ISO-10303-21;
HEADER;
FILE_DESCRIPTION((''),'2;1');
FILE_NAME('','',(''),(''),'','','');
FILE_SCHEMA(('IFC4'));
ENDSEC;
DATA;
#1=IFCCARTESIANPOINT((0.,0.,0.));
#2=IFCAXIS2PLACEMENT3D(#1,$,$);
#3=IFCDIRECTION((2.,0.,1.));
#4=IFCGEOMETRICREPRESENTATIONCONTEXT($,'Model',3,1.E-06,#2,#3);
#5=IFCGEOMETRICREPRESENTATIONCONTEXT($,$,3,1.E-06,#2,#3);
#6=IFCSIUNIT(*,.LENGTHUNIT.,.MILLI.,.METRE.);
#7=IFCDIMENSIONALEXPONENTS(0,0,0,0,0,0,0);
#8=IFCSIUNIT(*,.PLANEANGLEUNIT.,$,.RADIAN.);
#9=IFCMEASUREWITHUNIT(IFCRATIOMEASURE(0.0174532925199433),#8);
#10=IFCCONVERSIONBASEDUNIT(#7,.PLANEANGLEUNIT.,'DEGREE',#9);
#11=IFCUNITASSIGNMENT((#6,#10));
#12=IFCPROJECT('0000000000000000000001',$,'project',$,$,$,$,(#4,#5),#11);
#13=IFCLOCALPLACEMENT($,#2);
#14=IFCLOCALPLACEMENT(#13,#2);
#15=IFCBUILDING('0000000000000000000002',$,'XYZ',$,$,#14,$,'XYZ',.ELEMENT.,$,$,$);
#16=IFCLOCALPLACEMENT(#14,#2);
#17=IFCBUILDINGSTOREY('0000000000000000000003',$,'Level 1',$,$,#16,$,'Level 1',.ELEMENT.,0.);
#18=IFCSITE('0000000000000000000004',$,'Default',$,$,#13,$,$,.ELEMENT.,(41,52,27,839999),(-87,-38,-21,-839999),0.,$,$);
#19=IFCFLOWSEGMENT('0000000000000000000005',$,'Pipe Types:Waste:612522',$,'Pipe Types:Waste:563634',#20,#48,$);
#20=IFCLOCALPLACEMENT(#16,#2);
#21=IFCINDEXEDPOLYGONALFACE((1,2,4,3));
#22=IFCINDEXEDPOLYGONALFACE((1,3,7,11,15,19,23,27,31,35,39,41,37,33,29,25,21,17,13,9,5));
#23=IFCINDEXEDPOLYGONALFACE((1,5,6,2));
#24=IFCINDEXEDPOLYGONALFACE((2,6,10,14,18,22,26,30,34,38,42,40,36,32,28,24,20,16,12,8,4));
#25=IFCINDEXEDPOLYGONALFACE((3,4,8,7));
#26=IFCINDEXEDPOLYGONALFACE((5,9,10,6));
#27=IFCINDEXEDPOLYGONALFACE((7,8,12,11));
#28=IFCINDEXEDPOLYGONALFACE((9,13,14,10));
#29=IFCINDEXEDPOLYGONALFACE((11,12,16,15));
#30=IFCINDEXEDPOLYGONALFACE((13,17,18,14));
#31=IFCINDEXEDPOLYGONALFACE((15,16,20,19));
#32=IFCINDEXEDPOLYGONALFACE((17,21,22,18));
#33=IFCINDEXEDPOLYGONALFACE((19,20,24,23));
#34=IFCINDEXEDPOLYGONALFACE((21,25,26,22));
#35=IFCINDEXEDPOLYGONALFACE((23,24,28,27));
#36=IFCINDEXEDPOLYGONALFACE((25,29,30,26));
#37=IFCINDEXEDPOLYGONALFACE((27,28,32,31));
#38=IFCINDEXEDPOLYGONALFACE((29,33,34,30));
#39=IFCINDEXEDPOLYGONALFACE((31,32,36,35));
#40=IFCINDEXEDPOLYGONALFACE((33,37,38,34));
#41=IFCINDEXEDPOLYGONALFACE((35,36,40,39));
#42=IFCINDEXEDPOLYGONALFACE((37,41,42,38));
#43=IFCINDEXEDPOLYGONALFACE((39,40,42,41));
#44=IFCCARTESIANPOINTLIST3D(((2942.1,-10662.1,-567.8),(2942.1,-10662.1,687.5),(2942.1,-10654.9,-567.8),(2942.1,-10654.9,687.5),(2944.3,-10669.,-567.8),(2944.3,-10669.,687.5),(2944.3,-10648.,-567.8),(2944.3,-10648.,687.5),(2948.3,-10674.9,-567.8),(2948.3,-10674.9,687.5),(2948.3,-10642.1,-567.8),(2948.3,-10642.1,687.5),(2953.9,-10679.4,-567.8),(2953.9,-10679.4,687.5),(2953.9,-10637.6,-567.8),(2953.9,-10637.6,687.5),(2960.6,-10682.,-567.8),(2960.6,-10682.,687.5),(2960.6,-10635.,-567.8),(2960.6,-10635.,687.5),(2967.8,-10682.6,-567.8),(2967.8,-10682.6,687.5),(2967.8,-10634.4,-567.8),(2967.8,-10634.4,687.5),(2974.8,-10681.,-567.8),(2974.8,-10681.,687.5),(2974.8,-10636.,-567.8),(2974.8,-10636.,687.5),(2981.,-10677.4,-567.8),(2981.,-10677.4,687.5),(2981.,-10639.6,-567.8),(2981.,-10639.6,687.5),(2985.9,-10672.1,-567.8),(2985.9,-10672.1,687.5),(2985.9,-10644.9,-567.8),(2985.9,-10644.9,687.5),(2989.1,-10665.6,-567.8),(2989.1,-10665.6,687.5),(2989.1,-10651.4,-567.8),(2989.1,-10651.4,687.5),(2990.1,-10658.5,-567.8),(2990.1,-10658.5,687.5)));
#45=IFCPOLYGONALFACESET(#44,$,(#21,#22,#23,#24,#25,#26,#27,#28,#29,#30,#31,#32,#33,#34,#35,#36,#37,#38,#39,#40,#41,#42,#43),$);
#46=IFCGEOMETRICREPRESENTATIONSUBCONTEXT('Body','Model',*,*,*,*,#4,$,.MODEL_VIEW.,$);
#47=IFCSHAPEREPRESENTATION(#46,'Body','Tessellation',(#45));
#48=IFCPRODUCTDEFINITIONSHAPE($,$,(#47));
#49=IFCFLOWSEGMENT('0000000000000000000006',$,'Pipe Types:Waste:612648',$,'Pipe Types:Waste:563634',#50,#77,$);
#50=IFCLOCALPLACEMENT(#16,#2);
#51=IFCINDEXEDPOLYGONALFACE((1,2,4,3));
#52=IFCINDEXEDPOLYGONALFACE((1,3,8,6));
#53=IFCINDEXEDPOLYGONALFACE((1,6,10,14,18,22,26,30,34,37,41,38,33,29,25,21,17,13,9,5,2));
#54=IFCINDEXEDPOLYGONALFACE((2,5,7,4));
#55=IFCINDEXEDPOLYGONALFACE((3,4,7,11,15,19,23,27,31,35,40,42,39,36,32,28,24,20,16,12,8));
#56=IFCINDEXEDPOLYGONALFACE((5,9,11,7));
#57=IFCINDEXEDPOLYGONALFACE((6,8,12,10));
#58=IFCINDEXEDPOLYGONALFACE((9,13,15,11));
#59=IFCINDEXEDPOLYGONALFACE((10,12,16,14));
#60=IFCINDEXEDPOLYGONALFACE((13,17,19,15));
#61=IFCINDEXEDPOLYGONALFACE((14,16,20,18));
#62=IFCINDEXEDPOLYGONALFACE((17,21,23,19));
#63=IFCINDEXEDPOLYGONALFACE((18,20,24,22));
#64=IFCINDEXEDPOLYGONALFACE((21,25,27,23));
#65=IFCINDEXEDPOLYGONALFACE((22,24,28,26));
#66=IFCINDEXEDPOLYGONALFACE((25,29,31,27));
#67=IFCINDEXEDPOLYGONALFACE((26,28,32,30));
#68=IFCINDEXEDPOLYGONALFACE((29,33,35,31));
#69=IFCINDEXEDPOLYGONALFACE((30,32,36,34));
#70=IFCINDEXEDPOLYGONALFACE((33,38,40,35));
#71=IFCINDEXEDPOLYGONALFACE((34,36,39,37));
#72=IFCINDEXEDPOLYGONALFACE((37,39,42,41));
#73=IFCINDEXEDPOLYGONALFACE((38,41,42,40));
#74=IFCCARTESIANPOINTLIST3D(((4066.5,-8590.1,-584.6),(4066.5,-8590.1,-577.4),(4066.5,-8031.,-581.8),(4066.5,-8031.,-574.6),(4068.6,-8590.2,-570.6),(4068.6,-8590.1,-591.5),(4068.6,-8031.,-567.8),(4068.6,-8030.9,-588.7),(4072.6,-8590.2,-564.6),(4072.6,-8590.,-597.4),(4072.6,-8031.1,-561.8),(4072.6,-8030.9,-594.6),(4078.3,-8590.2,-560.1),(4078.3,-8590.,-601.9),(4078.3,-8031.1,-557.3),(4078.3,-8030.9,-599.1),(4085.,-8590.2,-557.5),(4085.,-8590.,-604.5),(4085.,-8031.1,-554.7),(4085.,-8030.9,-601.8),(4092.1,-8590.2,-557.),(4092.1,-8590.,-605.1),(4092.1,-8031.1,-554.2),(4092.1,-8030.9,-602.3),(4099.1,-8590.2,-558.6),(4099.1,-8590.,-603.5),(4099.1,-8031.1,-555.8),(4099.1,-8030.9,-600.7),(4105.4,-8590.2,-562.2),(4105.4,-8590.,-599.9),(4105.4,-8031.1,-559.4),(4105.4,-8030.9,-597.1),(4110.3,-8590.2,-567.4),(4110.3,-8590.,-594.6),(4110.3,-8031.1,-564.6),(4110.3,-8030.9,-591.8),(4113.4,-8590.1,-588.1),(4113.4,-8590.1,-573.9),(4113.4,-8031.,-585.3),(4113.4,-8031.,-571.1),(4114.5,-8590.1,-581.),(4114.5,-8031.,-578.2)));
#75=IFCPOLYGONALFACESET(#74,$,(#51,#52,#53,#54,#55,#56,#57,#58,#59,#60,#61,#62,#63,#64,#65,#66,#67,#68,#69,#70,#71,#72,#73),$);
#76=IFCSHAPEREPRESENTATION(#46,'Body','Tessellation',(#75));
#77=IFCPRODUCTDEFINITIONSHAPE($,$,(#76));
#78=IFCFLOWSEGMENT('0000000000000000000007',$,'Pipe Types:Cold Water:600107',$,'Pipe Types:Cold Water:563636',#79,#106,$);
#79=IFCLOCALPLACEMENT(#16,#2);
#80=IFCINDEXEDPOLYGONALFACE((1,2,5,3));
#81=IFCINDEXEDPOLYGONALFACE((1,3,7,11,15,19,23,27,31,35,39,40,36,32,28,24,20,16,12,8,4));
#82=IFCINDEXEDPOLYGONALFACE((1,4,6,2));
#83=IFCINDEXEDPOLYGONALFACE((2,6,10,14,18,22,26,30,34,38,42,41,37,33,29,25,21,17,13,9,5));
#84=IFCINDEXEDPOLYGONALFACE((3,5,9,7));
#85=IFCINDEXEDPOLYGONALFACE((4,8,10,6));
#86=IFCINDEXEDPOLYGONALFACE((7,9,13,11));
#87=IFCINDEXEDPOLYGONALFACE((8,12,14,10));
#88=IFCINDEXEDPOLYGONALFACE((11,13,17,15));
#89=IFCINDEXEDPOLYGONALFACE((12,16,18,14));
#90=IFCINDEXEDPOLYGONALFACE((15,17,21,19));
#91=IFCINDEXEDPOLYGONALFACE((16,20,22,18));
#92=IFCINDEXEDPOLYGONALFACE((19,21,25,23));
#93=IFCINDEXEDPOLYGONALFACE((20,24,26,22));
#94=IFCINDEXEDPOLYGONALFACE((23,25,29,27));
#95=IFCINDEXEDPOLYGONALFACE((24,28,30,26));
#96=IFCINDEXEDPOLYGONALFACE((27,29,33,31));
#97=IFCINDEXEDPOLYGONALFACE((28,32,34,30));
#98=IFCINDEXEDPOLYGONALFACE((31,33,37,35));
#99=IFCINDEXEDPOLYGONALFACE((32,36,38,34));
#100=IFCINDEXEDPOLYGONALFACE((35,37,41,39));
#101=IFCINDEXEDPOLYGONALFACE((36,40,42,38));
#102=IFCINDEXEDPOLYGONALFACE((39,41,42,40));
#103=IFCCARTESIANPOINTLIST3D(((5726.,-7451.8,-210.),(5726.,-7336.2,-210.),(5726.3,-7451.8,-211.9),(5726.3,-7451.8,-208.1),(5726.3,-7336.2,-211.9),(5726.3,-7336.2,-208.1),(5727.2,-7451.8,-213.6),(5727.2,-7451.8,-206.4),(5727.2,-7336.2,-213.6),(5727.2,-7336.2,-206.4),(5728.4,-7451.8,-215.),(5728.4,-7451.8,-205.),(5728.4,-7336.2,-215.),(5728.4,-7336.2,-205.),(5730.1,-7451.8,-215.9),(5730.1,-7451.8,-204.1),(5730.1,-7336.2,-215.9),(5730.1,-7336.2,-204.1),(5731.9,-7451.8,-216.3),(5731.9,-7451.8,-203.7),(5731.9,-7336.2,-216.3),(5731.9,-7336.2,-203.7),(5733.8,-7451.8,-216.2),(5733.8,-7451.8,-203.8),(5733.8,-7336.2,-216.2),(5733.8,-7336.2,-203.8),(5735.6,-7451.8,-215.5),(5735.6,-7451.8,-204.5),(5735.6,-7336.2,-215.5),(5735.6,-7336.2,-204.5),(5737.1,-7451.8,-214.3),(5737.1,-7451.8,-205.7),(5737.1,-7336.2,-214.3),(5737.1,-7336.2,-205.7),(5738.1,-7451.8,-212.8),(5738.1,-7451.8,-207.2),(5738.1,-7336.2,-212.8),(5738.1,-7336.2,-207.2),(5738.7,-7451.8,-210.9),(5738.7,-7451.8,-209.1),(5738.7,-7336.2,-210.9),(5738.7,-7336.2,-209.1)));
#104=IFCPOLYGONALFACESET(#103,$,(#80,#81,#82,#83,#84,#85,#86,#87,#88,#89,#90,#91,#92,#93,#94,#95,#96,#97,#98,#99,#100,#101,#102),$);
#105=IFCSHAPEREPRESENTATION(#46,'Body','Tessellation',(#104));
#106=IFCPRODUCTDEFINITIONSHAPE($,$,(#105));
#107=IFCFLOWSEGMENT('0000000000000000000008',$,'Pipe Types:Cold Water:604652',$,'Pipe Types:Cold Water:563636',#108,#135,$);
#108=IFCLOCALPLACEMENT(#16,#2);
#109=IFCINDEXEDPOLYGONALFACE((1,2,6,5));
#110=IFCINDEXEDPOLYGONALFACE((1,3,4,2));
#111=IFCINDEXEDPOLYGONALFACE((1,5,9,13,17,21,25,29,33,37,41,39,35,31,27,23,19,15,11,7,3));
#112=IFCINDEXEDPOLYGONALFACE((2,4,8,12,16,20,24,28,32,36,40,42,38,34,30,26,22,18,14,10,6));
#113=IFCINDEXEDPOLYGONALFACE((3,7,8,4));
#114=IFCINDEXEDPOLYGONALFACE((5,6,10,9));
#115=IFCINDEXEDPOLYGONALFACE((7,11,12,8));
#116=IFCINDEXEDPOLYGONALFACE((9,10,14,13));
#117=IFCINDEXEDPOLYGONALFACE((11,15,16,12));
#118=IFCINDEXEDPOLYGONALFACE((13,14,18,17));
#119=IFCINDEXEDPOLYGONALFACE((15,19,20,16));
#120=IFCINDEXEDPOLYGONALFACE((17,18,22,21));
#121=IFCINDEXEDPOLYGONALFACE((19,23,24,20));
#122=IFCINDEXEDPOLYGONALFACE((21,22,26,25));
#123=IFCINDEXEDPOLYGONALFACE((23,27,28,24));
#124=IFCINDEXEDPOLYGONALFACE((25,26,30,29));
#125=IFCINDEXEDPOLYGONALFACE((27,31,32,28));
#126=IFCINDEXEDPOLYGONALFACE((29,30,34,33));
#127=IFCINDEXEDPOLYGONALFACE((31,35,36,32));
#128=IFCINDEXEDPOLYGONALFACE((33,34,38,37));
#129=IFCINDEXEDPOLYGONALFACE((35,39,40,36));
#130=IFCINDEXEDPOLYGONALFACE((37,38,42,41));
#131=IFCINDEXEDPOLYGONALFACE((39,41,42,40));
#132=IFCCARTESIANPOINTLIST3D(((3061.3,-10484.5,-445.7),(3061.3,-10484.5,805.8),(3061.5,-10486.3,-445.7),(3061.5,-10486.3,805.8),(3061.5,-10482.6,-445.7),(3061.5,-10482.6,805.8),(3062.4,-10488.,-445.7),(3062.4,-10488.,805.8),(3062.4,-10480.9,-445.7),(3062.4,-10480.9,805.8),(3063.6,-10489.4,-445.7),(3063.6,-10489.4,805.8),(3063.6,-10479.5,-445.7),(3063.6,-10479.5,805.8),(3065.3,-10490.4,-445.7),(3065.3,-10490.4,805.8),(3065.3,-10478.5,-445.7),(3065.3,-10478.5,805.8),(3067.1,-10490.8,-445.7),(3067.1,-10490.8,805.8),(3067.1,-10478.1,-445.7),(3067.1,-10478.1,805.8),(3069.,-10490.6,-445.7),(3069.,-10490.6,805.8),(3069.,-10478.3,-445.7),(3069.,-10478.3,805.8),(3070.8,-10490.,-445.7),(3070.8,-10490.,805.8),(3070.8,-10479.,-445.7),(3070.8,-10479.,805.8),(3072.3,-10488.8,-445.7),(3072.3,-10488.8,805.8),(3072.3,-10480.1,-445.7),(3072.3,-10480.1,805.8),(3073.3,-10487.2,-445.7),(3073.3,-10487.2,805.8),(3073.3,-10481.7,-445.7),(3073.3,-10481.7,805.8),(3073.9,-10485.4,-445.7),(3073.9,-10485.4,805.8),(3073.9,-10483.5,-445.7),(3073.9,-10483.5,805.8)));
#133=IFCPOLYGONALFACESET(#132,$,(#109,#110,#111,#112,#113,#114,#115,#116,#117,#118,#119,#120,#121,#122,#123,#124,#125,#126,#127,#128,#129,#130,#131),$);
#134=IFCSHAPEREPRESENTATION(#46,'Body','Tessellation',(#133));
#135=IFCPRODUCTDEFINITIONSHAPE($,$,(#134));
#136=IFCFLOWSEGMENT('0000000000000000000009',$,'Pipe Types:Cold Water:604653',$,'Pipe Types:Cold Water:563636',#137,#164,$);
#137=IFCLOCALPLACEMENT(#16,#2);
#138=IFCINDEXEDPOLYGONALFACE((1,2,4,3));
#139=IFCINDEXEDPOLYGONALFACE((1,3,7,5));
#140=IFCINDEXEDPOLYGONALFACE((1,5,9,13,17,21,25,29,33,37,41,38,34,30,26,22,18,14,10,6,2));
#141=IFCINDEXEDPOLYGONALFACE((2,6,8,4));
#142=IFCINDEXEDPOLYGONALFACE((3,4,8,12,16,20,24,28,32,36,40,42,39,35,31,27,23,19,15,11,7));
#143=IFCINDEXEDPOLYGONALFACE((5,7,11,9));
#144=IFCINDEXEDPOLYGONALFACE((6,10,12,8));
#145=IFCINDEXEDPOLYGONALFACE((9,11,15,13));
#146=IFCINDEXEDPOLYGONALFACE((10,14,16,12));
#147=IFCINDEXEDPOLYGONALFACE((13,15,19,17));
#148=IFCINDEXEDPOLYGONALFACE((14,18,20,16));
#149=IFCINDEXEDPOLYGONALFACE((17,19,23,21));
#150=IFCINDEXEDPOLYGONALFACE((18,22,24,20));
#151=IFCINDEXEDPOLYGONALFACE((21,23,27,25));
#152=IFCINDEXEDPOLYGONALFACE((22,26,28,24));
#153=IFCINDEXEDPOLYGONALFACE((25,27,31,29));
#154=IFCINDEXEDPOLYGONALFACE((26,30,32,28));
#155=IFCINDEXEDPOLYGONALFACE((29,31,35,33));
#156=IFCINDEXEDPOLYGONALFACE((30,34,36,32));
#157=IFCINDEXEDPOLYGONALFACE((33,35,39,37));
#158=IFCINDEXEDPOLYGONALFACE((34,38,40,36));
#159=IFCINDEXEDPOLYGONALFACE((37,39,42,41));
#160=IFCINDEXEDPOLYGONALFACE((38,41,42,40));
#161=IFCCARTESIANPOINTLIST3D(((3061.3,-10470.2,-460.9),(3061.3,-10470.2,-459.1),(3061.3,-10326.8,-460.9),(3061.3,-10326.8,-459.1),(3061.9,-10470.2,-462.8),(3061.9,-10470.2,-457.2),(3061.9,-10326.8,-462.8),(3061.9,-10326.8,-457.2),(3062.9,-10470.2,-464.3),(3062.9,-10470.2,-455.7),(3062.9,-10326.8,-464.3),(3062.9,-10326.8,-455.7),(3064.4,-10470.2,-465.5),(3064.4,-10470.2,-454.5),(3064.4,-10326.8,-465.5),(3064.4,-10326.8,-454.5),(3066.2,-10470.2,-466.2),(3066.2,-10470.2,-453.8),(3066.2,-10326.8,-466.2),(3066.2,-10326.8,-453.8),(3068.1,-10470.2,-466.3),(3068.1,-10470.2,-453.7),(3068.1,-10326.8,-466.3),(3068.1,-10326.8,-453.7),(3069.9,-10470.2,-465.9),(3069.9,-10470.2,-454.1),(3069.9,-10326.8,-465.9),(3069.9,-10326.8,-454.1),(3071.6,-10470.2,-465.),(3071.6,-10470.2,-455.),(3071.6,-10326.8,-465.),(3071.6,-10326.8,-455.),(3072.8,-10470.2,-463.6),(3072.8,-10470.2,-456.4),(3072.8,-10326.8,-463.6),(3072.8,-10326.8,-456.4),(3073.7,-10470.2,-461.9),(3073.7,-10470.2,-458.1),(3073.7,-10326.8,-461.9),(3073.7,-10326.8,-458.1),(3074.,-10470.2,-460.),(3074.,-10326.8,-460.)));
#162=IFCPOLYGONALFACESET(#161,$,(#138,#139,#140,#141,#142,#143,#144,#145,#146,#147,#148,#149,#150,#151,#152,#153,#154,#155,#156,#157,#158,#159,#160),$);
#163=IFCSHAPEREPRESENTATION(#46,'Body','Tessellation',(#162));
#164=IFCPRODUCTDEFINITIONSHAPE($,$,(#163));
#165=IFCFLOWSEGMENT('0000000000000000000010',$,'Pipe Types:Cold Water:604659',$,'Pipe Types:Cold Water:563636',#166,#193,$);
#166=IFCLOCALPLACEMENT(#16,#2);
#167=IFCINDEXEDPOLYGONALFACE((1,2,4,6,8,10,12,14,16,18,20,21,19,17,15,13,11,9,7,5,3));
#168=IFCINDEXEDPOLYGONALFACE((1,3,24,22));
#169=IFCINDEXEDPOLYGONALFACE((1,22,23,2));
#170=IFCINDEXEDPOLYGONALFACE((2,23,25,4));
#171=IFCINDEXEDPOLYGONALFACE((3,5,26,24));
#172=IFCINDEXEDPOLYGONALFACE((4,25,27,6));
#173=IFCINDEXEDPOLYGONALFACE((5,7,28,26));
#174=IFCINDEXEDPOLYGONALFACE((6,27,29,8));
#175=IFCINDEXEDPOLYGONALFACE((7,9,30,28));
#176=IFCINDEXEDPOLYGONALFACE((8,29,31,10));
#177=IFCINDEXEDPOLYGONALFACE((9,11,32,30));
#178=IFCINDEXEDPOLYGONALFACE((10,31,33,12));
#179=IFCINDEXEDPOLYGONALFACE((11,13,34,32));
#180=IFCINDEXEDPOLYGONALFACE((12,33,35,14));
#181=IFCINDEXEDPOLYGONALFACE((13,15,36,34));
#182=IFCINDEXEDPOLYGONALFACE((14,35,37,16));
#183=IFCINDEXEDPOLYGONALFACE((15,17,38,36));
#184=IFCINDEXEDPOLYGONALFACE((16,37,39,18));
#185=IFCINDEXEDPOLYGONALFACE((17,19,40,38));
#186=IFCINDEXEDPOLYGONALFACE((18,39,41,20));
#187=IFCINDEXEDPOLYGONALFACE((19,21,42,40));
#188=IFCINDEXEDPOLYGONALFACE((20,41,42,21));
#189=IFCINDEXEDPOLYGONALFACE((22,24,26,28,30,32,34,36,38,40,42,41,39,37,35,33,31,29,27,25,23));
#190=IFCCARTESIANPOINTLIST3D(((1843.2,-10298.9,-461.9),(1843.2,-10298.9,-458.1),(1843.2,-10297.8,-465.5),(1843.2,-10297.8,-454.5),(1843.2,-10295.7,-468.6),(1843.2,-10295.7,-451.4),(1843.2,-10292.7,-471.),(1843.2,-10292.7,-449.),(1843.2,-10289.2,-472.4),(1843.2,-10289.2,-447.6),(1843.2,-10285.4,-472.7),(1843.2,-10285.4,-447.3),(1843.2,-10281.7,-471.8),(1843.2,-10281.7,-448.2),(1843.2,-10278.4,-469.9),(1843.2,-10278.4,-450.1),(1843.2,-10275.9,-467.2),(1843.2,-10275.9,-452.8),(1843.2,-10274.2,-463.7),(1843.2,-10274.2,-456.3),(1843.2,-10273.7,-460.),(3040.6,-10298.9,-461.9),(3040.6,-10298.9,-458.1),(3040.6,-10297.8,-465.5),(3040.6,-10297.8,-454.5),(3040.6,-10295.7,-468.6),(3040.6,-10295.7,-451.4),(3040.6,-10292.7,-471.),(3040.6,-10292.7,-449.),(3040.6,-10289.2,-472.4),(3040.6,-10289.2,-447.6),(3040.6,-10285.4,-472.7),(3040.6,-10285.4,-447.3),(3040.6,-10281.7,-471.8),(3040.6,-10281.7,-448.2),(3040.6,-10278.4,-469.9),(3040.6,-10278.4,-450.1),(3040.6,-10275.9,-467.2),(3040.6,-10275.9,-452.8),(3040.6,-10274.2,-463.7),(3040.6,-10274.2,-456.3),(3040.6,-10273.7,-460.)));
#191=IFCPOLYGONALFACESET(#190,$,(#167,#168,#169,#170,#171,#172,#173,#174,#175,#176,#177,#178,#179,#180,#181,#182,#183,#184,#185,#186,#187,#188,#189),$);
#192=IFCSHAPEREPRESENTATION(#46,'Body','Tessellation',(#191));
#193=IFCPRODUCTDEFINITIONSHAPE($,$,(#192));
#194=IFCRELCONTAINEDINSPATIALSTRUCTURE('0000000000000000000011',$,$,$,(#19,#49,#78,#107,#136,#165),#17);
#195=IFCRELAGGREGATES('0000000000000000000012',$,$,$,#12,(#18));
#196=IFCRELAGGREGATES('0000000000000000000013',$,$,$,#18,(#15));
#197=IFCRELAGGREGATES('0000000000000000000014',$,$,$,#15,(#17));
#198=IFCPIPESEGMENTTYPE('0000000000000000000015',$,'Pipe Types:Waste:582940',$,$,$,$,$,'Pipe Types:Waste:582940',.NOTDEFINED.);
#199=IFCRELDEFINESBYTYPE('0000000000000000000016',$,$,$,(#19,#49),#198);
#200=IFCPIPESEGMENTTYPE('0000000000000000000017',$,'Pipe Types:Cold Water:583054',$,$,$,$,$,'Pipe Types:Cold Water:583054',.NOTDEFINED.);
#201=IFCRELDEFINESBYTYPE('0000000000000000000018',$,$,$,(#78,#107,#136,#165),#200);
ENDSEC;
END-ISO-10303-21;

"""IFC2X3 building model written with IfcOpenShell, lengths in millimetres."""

from ifc_helpers import new_model, entity, si_unit, converted_unit, direction, frame, frame_2d, origin, origin_2d_with_axis, place, context, subcontext, project, spatial, circle, extrude, type_object, element, save


model = new_model("IFC2X3")

# Units and contexts
model_context = context("Model", 3, precision=1e-06, world=origin(), true_north=direction((2.0, 0.0, 1.0)))
context_of_model = context(None, 3, precision=1e-06, world=origin(), true_north=direction((2.0, 0.0, 1.0)))
body_context = subcontext(model_context, "Body", "Model", "MODEL_VIEW")
ifc_project = project(units=[si_unit("LENGTHUNIT", "METRE", prefix="MILLI"), converted_unit("PLANEANGLEUNIT", "DEGREE", entity("IfcRatioMeasure", 0.0174532925199433), si_unit("PLANEANGLEUNIT", "RADIAN"), dimensions=[0, 0, 0, 0, 0, 0, 0])], contexts=[model_context, context_of_model])

# Site, building, storey
site_placement = place(None, origin())
site = spatial("IfcSite", under=ifc_project, at=site_placement, Name="Default", CompositionType="ELEMENT", RefLatitude=(41, 52, 27, 839999), RefLongitude=(-87, -38, -21, -839999), RefElevation=0.0)
building_placement = place(site_placement, origin())
building = spatial("IfcBuilding", under=site, at=building_placement, Name="XYZ", LongName="XYZ", CompositionType="ELEMENT")
storey_placement = place(building_placement, origin())
storey = spatial("IfcBuildingStorey", under=building, at=storey_placement, Name="Level 1", LongName="Level 1", CompositionType="ELEMENT", Elevation=0.0)

# Flow segments
pipe_segment_type_1 = type_object("IfcPipeSegmentType", Name="Pipe Types:Waste:582940", ElementType="Pipe Types:Waste:582940", PredefinedType="NOTDEFINED")
flow_segment_1_placement = place(storey_placement, origin())
element("IfcFlowSegment", 1, at=flow_segment_1_placement, inside=storey, type_object=pipe_segment_type_1, Name="Pipe Types:Waste:612522", ObjectType="Pipe Types:Waste:563634", context=body_context, shape_type="SweptSolid", body=[
    extrude(circle(Radius=24.1, at=origin_2d_with_axis()), frame((2966.0, -10658.5, -567.8)), (0.0, 0.0, 1.0), 1255.3),
])
flow_segment_2_placement = place(storey_placement, origin())
element("IfcFlowSegment", 2, at=flow_segment_2_placement, inside=storey, type_object=pipe_segment_type_1, Name="Pipe Types:Waste:612648", ObjectType="Pipe Types:Waste:563634", context=body_context, shape_type="SweptSolid", body=[
    extrude(circle(Radius=24.1, at=frame_2d((0.0, 0.0), x_axis=(1.0, 0.0))), frame((4090.3, -8590.1, -581.0), z_axis=(0.0, 0.999988, 0.005), x_axis=(1.0, 0.0, 0.0)), (0.0, 0.0, 1.0), 559.1),
])
pipe_segment_type_2 = type_object("IfcPipeSegmentType", Name="Pipe Types:Cold Water:583054", ElementType="Pipe Types:Cold Water:583054", PredefinedType="NOTDEFINED")
flow_segment_3_placement = place(storey_placement, origin())
element("IfcFlowSegment", 3, at=flow_segment_3_placement, inside=storey, type_object=pipe_segment_type_2, Name="Pipe Types:Cold Water:600107", ObjectType="Pipe Types:Cold Water:563636", context=body_context, shape_type="SweptSolid", body=[
    extrude(circle(Radius=6.3, at=frame_2d((0.0, 0.0), x_axis=(1.0, 0.0))), frame((5732.4, -7451.8, -210.0), z_axis=(0.0, 1.0, 0.0), x_axis=(-1.0, 0.0, 0.0)), (0.0, 0.0, 1.0), 115.6),
])
flow_segment_4_placement = place(storey_placement, origin())
element("IfcFlowSegment", 4, at=flow_segment_4_placement, inside=storey, type_object=pipe_segment_type_2, Name="Pipe Types:Cold Water:604652", ObjectType="Pipe Types:Cold Water:563636", context=body_context, shape_type="SweptSolid", body=[
    extrude(circle(Radius=6.3, at=origin_2d_with_axis()), frame((3067.6, -10484.5, -445.7), z_axis=(0.0, 0.0, 1.0), x_axis=(-1.0, 0.0, 0.0)), (0.0, 0.0, 1.0), 1251.5),
])
flow_segment_5_placement = place(storey_placement, origin())
element("IfcFlowSegment", 5, at=flow_segment_5_placement, inside=storey, type_object=pipe_segment_type_2, Name="Pipe Types:Cold Water:604653", ObjectType="Pipe Types:Cold Water:563636", context=body_context, shape_type="SweptSolid", body=[
    extrude(circle(Radius=6.3, at=origin_2d_with_axis()), frame((3067.6, -10470.2, -460.0), z_axis=(0.0, 1.0, 0.0), x_axis=(1.0, 0.0, 0.0)), (0.0, 0.0, 1.0), 143.3),
])
flow_segment_6_placement = place(storey_placement, origin())
element("IfcFlowSegment", 6, at=flow_segment_6_placement, inside=storey, type_object=pipe_segment_type_2, Name="Pipe Types:Cold Water:604659", ObjectType="Pipe Types:Cold Water:563636", context=body_context, shape_type="SweptSolid", body=[
    extrude(circle(Radius=12.7, at=frame_2d((0.0, 0.0), x_axis=(1.0, 0.0))), frame((1843.2, -10286.4, -460.0), z_axis=(1.0, 0.0, 0.0), x_axis=(0.0, 1.0, 0.0)), (0.0, 0.0, 1.0), 1197.4),
])

save(model, "model.ifc")
